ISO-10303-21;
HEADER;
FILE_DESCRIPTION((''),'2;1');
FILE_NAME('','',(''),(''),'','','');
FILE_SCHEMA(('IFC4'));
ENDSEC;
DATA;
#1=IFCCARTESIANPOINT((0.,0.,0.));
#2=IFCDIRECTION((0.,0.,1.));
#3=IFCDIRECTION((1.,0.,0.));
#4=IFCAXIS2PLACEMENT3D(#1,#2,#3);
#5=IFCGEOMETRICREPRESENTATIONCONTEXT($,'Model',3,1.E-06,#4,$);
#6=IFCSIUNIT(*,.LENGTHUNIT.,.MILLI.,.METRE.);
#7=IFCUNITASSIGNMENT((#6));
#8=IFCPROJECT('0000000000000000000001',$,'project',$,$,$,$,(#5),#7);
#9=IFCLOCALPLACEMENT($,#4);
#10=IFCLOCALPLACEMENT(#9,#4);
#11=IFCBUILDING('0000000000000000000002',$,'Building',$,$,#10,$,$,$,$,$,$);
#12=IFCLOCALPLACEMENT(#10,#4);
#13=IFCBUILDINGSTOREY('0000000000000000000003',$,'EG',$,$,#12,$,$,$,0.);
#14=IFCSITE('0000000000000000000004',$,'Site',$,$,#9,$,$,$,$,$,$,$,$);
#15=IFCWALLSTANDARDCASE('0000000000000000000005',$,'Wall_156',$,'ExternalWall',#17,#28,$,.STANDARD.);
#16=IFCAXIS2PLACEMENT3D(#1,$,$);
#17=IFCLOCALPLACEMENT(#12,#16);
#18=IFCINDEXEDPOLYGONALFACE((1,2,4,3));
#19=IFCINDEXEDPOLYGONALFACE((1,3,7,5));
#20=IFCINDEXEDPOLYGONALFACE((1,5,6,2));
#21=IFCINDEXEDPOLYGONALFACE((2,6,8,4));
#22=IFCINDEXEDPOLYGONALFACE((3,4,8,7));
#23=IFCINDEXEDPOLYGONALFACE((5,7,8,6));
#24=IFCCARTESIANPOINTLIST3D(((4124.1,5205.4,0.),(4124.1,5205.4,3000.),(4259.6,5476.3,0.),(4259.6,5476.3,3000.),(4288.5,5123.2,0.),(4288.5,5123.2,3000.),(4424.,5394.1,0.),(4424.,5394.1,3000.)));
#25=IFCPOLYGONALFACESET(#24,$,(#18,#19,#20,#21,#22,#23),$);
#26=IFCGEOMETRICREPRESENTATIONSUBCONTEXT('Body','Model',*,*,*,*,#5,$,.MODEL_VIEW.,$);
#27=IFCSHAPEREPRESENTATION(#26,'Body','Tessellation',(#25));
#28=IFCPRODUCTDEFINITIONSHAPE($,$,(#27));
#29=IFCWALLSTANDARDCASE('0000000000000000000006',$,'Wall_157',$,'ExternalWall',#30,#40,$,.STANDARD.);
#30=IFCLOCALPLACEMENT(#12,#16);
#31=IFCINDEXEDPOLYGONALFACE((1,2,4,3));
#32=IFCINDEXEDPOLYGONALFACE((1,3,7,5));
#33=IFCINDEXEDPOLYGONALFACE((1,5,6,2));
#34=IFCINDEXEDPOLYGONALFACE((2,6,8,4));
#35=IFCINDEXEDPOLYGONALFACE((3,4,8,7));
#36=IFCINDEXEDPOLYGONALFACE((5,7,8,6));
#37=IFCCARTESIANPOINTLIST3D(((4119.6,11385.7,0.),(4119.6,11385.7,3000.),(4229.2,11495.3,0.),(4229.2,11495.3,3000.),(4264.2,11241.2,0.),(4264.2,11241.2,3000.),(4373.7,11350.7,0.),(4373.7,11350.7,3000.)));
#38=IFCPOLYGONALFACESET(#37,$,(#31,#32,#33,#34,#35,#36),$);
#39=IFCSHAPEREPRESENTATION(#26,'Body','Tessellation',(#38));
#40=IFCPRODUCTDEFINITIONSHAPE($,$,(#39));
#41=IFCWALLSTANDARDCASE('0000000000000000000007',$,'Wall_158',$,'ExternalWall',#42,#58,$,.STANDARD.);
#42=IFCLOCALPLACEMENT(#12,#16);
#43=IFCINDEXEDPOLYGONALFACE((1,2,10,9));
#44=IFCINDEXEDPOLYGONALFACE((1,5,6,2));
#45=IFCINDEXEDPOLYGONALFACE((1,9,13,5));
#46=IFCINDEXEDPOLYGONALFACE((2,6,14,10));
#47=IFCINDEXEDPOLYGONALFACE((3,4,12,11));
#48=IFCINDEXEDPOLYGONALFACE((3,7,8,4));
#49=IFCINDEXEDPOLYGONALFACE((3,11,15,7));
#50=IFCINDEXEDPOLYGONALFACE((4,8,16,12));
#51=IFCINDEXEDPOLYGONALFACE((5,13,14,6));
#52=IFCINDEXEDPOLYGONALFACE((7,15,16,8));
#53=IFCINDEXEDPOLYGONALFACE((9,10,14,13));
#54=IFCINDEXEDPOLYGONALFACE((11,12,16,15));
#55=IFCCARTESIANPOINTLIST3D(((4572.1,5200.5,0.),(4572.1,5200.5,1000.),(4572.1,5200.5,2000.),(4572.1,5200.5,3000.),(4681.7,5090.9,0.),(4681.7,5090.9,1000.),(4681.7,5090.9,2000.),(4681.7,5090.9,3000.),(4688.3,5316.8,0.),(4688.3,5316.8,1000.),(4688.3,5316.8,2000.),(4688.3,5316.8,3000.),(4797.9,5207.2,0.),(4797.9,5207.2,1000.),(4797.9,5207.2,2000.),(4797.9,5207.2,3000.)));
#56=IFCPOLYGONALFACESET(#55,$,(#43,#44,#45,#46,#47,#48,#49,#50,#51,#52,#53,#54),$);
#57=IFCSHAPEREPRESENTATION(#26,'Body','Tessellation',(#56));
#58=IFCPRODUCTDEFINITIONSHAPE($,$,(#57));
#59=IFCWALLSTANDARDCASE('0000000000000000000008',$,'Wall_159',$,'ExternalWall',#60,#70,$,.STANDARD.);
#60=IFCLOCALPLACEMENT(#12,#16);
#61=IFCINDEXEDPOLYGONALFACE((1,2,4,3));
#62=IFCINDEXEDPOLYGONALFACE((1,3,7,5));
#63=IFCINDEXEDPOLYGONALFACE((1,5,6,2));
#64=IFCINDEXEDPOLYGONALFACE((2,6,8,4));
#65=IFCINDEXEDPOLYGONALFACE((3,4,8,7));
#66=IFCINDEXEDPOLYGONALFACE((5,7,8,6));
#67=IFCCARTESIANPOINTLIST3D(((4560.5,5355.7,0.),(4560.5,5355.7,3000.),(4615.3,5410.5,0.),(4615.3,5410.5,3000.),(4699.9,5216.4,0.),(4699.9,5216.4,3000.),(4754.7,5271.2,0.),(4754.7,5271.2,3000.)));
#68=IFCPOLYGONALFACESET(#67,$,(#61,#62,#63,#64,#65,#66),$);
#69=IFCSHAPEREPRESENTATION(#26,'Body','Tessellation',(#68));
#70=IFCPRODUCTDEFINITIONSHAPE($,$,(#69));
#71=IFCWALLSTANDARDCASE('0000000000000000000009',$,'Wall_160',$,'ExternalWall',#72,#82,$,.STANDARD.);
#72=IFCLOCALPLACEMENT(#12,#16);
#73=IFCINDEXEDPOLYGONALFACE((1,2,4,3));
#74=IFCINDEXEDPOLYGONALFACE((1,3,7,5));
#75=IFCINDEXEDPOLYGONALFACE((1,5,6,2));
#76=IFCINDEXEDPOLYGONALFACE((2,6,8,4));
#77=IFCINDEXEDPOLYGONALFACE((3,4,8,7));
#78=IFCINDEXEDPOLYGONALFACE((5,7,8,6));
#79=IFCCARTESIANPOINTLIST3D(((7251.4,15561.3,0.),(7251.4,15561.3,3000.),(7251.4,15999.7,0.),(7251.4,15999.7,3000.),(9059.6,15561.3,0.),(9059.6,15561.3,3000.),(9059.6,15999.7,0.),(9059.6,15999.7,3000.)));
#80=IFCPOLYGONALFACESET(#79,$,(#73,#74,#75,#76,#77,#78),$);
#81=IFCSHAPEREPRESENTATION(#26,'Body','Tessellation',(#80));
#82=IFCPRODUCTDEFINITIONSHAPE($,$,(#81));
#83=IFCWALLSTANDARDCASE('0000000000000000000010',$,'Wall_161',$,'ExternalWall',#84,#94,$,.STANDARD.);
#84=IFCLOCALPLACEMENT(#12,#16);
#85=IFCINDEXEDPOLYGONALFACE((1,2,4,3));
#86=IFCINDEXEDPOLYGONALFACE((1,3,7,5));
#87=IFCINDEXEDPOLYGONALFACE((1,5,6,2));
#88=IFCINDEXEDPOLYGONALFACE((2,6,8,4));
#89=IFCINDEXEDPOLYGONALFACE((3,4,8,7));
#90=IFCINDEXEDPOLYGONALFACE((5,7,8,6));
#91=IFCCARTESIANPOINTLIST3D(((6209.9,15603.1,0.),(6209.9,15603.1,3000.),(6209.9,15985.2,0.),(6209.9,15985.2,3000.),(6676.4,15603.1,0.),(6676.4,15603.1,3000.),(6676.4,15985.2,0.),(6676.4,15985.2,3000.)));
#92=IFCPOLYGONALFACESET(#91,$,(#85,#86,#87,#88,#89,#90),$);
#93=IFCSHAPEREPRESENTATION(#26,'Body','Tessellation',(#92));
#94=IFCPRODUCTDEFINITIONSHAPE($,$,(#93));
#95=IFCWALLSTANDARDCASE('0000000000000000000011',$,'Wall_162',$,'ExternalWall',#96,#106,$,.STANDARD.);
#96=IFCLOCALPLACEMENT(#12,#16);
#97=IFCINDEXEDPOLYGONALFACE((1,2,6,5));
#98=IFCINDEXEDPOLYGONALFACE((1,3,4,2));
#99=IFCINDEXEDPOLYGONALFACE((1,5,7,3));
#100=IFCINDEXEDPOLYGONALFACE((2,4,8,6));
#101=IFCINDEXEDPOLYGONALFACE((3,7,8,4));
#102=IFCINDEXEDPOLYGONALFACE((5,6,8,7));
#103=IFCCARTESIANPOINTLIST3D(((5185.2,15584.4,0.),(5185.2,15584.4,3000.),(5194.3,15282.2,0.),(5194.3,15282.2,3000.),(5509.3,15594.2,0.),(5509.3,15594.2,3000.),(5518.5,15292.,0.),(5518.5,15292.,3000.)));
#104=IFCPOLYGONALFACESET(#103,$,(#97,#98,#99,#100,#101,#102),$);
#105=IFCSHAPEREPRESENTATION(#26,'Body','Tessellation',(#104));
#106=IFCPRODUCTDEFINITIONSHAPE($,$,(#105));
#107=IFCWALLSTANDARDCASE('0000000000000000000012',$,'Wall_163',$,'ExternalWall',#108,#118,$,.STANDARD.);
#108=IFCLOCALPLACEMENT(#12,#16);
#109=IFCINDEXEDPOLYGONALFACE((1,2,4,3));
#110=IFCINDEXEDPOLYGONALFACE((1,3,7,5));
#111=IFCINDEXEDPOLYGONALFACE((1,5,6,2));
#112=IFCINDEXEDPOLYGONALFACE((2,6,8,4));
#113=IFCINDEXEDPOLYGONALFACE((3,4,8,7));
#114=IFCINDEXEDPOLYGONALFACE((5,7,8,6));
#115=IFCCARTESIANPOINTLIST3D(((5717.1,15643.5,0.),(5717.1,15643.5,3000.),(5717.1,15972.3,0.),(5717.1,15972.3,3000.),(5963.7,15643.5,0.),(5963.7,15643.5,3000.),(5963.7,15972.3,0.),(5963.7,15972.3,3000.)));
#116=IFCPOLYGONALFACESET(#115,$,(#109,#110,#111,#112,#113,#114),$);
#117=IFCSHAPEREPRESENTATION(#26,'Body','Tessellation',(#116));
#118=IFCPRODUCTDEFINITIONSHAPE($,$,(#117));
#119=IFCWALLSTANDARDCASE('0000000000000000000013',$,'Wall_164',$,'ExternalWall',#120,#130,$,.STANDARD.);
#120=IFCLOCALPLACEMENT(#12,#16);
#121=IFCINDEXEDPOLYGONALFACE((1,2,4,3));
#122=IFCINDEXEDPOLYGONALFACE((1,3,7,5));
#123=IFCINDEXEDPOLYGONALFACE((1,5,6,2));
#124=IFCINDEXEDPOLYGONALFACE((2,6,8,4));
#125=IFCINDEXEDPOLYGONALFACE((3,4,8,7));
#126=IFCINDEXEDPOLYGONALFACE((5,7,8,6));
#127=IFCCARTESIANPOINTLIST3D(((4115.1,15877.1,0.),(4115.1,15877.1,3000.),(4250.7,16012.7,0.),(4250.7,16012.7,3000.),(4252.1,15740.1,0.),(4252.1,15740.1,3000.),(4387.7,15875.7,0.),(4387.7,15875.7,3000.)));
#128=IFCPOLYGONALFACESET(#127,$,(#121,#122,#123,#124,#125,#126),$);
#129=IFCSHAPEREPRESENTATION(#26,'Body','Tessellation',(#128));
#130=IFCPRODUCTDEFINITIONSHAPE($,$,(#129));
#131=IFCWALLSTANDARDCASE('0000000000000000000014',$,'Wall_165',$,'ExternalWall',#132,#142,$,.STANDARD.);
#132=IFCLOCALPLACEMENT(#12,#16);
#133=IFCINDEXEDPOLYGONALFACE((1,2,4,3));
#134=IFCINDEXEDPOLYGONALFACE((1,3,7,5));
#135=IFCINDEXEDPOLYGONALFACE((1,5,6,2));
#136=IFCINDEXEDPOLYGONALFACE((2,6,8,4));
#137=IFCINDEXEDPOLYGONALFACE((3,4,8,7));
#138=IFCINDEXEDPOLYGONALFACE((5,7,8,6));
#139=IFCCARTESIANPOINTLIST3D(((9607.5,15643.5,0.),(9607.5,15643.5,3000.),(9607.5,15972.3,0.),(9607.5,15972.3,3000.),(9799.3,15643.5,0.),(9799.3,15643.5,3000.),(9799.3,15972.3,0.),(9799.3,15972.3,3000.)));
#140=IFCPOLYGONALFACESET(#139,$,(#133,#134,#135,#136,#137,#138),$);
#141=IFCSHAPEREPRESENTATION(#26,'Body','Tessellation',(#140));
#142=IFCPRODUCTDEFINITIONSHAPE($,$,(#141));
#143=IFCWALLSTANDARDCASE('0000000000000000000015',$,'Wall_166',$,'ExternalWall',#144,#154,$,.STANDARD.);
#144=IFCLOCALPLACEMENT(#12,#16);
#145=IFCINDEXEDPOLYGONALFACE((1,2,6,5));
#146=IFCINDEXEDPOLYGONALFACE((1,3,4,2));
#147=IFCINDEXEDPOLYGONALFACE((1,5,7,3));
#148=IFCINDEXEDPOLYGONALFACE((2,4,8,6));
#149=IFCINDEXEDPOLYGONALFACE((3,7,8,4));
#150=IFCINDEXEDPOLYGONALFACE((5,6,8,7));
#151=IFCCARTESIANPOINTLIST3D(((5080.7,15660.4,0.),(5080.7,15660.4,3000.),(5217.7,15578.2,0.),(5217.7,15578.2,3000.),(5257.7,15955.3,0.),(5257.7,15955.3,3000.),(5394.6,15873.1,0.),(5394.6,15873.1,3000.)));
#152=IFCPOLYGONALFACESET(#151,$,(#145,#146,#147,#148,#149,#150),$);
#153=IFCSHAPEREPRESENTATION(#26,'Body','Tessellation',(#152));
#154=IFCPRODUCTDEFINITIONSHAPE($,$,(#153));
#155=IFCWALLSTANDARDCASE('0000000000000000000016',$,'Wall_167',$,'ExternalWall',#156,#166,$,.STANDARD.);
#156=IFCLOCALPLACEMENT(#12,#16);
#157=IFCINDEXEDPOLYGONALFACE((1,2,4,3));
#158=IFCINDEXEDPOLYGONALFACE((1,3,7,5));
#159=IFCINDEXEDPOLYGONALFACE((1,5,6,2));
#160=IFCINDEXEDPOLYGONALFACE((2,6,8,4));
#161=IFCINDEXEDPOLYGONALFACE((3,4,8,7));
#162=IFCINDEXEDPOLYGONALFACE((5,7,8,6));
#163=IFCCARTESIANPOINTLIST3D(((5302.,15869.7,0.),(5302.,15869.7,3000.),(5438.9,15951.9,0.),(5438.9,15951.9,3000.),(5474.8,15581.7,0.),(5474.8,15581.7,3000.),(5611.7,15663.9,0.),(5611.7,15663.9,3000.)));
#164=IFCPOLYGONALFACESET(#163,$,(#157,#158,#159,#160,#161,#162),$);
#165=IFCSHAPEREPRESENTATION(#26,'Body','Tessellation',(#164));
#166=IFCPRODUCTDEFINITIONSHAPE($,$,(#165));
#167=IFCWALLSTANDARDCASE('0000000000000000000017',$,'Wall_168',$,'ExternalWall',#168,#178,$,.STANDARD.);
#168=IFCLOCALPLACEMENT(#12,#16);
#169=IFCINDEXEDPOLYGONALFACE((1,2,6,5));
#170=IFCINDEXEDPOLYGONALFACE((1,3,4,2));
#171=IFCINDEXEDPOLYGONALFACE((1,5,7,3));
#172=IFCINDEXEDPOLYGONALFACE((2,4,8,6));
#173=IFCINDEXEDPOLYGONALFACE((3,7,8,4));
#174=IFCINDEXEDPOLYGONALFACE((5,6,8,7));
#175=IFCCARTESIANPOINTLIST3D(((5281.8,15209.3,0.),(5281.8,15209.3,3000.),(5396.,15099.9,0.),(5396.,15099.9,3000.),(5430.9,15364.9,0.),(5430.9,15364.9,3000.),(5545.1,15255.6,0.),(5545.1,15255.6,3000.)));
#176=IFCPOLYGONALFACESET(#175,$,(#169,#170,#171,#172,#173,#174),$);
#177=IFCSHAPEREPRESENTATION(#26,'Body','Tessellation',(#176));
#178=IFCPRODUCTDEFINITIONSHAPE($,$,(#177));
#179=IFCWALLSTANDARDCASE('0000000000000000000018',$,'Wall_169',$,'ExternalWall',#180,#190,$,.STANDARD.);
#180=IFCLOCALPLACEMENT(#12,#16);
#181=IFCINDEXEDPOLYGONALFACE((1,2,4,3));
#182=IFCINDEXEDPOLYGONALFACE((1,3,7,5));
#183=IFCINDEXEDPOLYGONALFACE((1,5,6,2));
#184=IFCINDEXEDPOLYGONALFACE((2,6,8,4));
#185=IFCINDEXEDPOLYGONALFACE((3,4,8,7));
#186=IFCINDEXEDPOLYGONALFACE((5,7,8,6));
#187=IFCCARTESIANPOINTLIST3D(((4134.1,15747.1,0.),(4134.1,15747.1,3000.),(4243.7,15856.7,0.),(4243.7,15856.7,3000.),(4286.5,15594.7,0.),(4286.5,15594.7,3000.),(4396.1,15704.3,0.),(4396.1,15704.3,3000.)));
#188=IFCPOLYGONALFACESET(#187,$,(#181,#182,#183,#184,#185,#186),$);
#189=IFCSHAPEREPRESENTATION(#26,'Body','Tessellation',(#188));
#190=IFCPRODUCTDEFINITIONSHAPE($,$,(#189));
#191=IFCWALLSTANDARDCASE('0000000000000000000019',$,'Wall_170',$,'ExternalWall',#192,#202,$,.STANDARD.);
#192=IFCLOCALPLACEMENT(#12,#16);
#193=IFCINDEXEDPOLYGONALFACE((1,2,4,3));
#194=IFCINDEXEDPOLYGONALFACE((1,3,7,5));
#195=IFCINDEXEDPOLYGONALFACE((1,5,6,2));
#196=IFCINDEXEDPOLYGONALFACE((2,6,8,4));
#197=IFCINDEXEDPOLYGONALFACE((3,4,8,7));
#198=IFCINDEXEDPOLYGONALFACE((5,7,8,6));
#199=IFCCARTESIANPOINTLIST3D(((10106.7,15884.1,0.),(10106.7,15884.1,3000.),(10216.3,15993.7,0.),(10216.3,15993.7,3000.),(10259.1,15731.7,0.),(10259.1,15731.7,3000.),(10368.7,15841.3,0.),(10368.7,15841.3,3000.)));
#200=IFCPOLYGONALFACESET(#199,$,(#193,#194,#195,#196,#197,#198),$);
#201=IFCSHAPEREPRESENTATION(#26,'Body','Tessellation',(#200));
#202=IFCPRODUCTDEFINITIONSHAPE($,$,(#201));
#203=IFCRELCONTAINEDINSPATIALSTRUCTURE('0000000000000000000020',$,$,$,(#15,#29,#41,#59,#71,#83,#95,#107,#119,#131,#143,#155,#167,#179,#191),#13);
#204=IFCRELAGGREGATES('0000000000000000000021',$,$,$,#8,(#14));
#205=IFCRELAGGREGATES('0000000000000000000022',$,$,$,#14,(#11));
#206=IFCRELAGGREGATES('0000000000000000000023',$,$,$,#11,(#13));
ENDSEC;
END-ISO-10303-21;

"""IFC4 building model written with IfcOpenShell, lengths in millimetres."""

from ifc_helpers import new_model, si_unit, frame, origin_with_axes, place, context, subcontext, project, spatial, rectangle, extrude, element, save


model = new_model("IFC4")

# Units and contexts
model_context = context("Model", 3, precision=1e-06, world=origin_with_axes())
body_context = subcontext(model_context, "Body", "Model", "MODEL_VIEW")
ifc_project = project(units=[si_unit("LENGTHUNIT", "METRE", prefix="MILLI")], contexts=[model_context])

# Site, building, storey
site_placement = place(None, origin_with_axes())
site = spatial("IfcSite", under=ifc_project, at=site_placement, Name="Site")
building_placement = place(site_placement, origin_with_axes())
building = spatial("IfcBuilding", under=site, at=building_placement, Name="Building")
storey_placement = place(building_placement, origin_with_axes())
storey = spatial("IfcBuildingStorey", under=building, at=storey_placement, Name="EG", Elevation=0.0)

# Walls
wall_1_placement = place(storey_placement, origin_with_axes())
element("IfcWallStandardCase", 1, at=wall_1_placement, inside=storey, Name="Wall_156", ObjectType="ExternalWall", PredefinedType="STANDARD", context=body_context, shape_type="SweptSolid", body=[
    extrude(rectangle(XDim=183.8, YDim=302.9), frame((4274.1, 5299.7, 0.0), z_axis=(0.0, 0.0, 1.0), x_axis=(-0.894427, 0.447214, 0.0)), (0.0, 0.0, 1.0), 3000.0),
])
wall_2_placement = place(storey_placement, origin_with_axes())
element("IfcWallStandardCase", 2, at=wall_2_placement, inside=storey, Name="Wall_157", ObjectType="ExternalWall", PredefinedType="STANDARD", context=body_context, shape_type="SweptSolid", body=[
    extrude(rectangle(XDim=155.0, YDim=204.5), frame((4246.7, 11368.2, 0.0), z_axis=(0.0, 0.0, 1.0), x_axis=(0.707107, 0.707107, 0.0)), (0.0, 0.0, 1.0), 3000.0),
])

# Wall, opening
wall_3_placement = place(storey_placement, origin_with_axes())
wall_3 = element("IfcWallStandardCase", 3, at=wall_3_placement, inside=storey, Name="Wall_158", ObjectType="ExternalWall", PredefinedType="STANDARD", context=body_context, shape_type="SweptSolid", body=[
    extrude(rectangle(XDim=155.0, YDim=164.4), frame((4685.0, 5203.9, 0.0), z_axis=(0.0, 0.0, 1.0), x_axis=(0.707107, -0.707107, 0.0)), (0.0, 0.0, 1.0), 3000.0),
])
opening_1_placement = place(wall_3_placement, origin_with_axes())
element("IfcOpeningElement", 4, at=opening_1_placement, inside=storey, cuts=wall_3, context=body_context, shape_type="SweptSolid", body=[
    extrude(rectangle(XDim=600.0, YDim=164.4), frame((4685.0, 5203.9, 1000.0), z_axis=(0.0, 0.0, 1.0), x_axis=(0.707107, -0.707107, 0.0)), (0.0, 0.0, 1.0), 1000.0),
])

# Walls
wall_4_placement = place(storey_placement, origin_with_axes())
element("IfcWallStandardCase", 5, at=wall_4_placement, inside=storey, Name="Wall_159", ObjectType="ExternalWall", PredefinedType="STANDARD", context=body_context, shape_type="SweptSolid", body=[
    extrude(rectangle(XDim=77.5, YDim=197.1), frame((4657.6, 5313.4, 0.0), z_axis=(0.0, 0.0, 1.0), x_axis=(0.707107, 0.707107, 0.0)), (0.0, 0.0, 1.0), 3000.0),
])
wall_5_placement = place(storey_placement, origin_with_axes())
element("IfcWallStandardCase", 6, at=wall_5_placement, inside=storey, Name="Wall_160", ObjectType="ExternalWall", PredefinedType="STANDARD", context=body_context, shape_type="SweptSolid", body=[
    extrude(rectangle(XDim=1808.2, YDim=438.4), frame((8155.5, 15780.5, 0.0), z_axis=(0.0, 0.0, 1.0), x_axis=(1.0, 0.0, 0.0)), (0.0, 0.0, 1.0), 3000.0),
])
wall_6_placement = place(storey_placement, origin_with_axes())
element("IfcWallStandardCase", 7, at=wall_6_placement, inside=storey, Name="Wall_161", ObjectType="ExternalWall", PredefinedType="STANDARD", context=body_context, shape_type="SweptSolid", body=[
    extrude(rectangle(XDim=466.6, YDim=382.1), frame((6443.2, 15794.2, 0.0), z_axis=(0.0, 0.0, 1.0), x_axis=(1.0, 0.0, 0.0)), (0.0, 0.0, 1.0), 3000.0),
])
wall_7_placement = place(storey_placement, origin_with_axes())
element("IfcWallStandardCase", 8, at=wall_7_placement, inside=storey, Name="Wall_162", ObjectType="ExternalWall", PredefinedType="STANDARD", context=body_context, shape_type="SweptSolid", body=[
    extrude(rectangle(XDim=302.3, YDim=324.3), frame((5351.8, 15438.2, 0.0), z_axis=(0.0, 0.0, 1.0), x_axis=(0.030206, -0.999544, 0.0)), (0.0, 0.0, 1.0), 3000.0),
])
wall_8_placement = place(storey_placement, origin_with_axes())
element("IfcWallStandardCase", 9, at=wall_8_placement, inside=storey, Name="Wall_163", ObjectType="ExternalWall", PredefinedType="STANDARD", context=body_context, shape_type="SweptSolid", body=[
    extrude(rectangle(XDim=246.6, YDim=328.8), frame((5840.4, 15807.9, 0.0), z_axis=(0.0, 0.0, 1.0), x_axis=(1.0, 0.0, 0.0)), (0.0, 0.0, 1.0), 3000.0),
])
wall_9_placement = place(storey_placement, origin_with_axes())
element("IfcWallStandardCase", 10, at=wall_9_placement, inside=storey, Name="Wall_164", ObjectType="ExternalWall", PredefinedType="STANDARD", context=body_context, shape_type="SweptSolid", body=[
    extrude(rectangle(XDim=193.7, YDim=191.8), frame((4251.4, 15876.4, 0.0), z_axis=(0.0, 0.0, 1.0), x_axis=(-0.707107, 0.707107, 0.0)), (0.0, 0.0, 1.0), 3000.0),
])
wall_10_placement = place(storey_placement, origin_with_axes())
element("IfcWallStandardCase", 11, at=wall_10_placement, inside=storey, Name="Wall_165", ObjectType="ExternalWall", PredefinedType="STANDARD", context=body_context, shape_type="SweptSolid", body=[
    extrude(rectangle(XDim=191.8, YDim=328.8), frame((9703.4, 15807.9, 0.0), z_axis=(0.0, 0.0, 1.0), x_axis=(1.0, 0.0, 0.0)), (0.0, 0.0, 1.0), 3000.0),
])
wall_11_placement = place(storey_placement, origin_with_axes())
element("IfcWallStandardCase", 12, at=wall_11_placement, inside=storey, Name="Wall_166", ObjectType="ExternalWall", PredefinedType="STANDARD", context=body_context, shape_type="SweptSolid", body=[
    extrude(rectangle(XDim=159.8, YDim=343.9), frame((5237.7, 15766.8, 0.0), z_axis=(0.0, 0.0, 1.0), x_axis=(0.857493, -0.514496, 0.0)), (0.0, 0.0, 1.0), 3000.0),
])
wall_12_placement = place(storey_placement, origin_with_axes())
element("IfcWallStandardCase", 13, at=wall_12_placement, inside=storey, Name="Wall_167", ObjectType="ExternalWall", PredefinedType="STANDARD", context=body_context, shape_type="SweptSolid", body=[
    extrude(rectangle(XDim=159.8, YDim=335.8), frame((5456.8, 15766.8, 0.0), z_axis=(0.0, 0.0, 1.0), x_axis=(0.857493, 0.514496, 0.0)), (0.0, 0.0, 1.0), 3000.0),
])
wall_13_placement = place(storey_placement, origin_with_axes())
element("IfcWallStandardCase", 14, at=wall_13_placement, inside=storey, Name="Wall_168", ObjectType="ExternalWall", PredefinedType="STANDARD", context=body_context, shape_type="SweptSolid", body=[
    extrude(rectangle(XDim=158.1, YDim=215.5), frame((5413.5, 15232.4, 0.0), z_axis=(0.0, 0.0, 1.0), x_axis=(0.722042, -0.69185, 0.0)), (0.0, 0.0, 1.0), 3000.0),
])
wall_14_placement = place(storey_placement, origin_with_axes())
element("IfcWallStandardCase", 15, at=wall_14_placement, inside=storey, Name="Wall_169", ObjectType="ExternalWall", PredefinedType="STANDARD", context=body_context, shape_type="SweptSolid", body=[
    extrude(rectangle(XDim=155.0, YDim=215.5), frame((4265.1, 15725.7, 0.0), z_axis=(0.0, 0.0, 1.0), x_axis=(-0.707107, -0.707107, 0.0)), (0.0, 0.0, 1.0), 3000.0),
])
wall_15_placement = place(storey_placement, origin_with_axes())
element("IfcWallStandardCase", 16, at=wall_15_placement, inside=storey, Name="Wall_170", ObjectType="ExternalWall", PredefinedType="STANDARD", context=body_context, shape_type="SweptSolid", body=[
    extrude(rectangle(XDim=155.0, YDim=215.5), frame((10237.7, 15862.7, 0.0), z_axis=(0.0, 0.0, 1.0), x_axis=(0.707107, 0.707107, 0.0)), (0.0, 0.0, 1.0), 3000.0),
])

save(model, "model.ifc")
